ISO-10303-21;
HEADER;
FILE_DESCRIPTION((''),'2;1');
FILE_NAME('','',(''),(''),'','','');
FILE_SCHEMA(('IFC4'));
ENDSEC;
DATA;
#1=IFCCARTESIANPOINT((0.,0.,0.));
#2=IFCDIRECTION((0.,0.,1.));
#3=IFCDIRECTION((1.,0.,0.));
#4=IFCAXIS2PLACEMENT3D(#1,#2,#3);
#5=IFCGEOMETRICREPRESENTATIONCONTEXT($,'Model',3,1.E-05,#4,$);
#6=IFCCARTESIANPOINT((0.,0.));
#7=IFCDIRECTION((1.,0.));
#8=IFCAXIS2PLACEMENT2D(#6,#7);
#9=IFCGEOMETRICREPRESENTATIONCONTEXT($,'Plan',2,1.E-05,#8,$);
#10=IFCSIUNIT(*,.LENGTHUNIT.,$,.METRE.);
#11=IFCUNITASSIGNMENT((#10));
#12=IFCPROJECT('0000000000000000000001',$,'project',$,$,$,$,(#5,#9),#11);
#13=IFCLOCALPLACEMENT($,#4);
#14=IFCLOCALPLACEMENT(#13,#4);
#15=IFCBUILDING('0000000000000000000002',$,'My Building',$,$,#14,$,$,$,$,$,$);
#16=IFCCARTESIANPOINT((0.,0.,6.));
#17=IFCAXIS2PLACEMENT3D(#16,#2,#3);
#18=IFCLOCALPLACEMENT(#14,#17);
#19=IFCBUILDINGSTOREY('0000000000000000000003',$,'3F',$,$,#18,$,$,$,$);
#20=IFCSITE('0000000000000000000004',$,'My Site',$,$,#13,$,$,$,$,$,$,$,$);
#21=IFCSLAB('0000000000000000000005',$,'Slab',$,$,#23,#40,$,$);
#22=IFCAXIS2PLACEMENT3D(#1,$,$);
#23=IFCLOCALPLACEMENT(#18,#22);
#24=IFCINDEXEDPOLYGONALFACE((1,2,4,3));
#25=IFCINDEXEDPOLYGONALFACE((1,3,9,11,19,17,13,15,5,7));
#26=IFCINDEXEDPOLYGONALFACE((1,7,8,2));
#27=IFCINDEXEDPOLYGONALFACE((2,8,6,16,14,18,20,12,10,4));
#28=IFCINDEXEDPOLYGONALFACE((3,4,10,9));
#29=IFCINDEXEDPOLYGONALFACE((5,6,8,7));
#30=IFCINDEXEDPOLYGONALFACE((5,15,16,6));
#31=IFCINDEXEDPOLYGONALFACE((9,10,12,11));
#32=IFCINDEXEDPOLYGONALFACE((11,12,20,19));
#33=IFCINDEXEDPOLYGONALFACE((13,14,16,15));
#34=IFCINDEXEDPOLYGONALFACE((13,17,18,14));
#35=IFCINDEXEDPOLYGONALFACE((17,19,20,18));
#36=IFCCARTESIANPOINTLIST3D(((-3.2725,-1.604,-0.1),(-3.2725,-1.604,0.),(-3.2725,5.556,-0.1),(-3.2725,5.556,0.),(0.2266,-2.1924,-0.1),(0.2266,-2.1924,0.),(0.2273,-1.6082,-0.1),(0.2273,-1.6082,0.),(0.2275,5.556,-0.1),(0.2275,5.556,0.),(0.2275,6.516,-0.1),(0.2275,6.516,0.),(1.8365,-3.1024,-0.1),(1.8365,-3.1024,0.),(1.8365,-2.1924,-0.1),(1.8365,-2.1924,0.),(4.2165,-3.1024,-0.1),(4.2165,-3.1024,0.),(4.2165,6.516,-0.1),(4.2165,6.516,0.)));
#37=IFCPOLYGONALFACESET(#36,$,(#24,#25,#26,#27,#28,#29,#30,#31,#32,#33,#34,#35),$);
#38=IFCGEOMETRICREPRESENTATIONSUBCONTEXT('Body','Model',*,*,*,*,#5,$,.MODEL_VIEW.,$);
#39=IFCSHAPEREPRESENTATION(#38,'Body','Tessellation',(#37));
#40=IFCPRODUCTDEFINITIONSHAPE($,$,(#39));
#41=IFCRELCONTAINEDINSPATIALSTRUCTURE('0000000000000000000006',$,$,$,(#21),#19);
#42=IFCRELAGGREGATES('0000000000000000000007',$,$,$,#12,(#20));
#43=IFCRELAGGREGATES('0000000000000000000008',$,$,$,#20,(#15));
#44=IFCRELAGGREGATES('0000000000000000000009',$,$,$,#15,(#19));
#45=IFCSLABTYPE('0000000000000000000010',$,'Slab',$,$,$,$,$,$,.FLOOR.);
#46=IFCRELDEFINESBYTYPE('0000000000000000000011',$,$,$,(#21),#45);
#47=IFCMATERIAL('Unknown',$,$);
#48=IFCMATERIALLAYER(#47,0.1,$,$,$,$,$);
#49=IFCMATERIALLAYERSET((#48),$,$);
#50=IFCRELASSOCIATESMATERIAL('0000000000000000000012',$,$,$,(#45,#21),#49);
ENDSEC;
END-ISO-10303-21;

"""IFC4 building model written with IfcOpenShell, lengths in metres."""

from ifc_helpers import new_model, si_unit, frame, origin_with_axes, origin_2d_with_axis, place, context, subcontext, project, spatial, indexed_curve, outline, extrude, material, layer, layer_set, layer_usage, type_object, element, save


model = new_model("IFC4")

# Units and contexts
model_context = context("Model", 3, precision=1e-05, world=origin_with_axes())
plan_context = context("Plan", 2, precision=1e-05, world=origin_2d_with_axis())
body_context = subcontext(model_context, "Body", "Model", "MODEL_VIEW")
ifc_project = project(units=[si_unit("LENGTHUNIT", "METRE")], contexts=[model_context, plan_context])

# Site, building, storey
site_placement = place(None, origin_with_axes())
site = spatial("IfcSite", under=ifc_project, at=site_placement, Name="My Site")
building_placement = place(site_placement, origin_with_axes())
building = spatial("IfcBuilding", under=site, at=building_placement, Name="My Building")
storey_placement = place(building_placement, frame((0.0, 0.0, 6.0), z_axis=(0.0, 0.0, 1.0), x_axis=(1.0, 0.0, 0.0)))
storey = spatial("IfcBuildingStorey", under=building, at=storey_placement, Name="3F")

# Slab
ifc_material = material(Name="Unknown")
ifc_layer = layer(ifc_material, 0.1)
ifc_layer_set = layer_set([ifc_layer])
ifc_layer_usage = layer_usage(ifc_layer_set, "AXIS3", "POSITIVE", -0.1)
slab_type = type_object("IfcSlabType", Name="Slab", PredefinedType="FLOOR", material=ifc_layer_set)
slab_placement = place(storey_placement, frame((4.2165, 6.516, 0.0), z_axis=(0.0, 0.0, 1.0), x_axis=(1.0, 0.0, 0.0)))
element("IfcSlab", 1, at=slab_placement, inside=storey, type_object=slab_type, material=ifc_layer_usage, Name="Slab", context=body_context, shape_type="SweptSolid", body=[
    extrude(outline(indexed_curve([(0.0, 0.0), (-3.989, 0.0), (-3.989, -0.96), (-7.489, -0.96), (-7.489, -8.12), (-3.9892, -8.1242), (-3.9899, -8.7084), (-2.38, -8.7084), (-2.38, -9.6184), (0.0, -9.6184), (0.0, 0.0)])), frame((0.0, 0.0, -0.1), z_axis=(0.0, 0.0, 1.0), x_axis=(1.0, 0.0, 0.0)), (0.0, 0.0, 1.0), 0.1),
])

save(model, "model.ifc")
